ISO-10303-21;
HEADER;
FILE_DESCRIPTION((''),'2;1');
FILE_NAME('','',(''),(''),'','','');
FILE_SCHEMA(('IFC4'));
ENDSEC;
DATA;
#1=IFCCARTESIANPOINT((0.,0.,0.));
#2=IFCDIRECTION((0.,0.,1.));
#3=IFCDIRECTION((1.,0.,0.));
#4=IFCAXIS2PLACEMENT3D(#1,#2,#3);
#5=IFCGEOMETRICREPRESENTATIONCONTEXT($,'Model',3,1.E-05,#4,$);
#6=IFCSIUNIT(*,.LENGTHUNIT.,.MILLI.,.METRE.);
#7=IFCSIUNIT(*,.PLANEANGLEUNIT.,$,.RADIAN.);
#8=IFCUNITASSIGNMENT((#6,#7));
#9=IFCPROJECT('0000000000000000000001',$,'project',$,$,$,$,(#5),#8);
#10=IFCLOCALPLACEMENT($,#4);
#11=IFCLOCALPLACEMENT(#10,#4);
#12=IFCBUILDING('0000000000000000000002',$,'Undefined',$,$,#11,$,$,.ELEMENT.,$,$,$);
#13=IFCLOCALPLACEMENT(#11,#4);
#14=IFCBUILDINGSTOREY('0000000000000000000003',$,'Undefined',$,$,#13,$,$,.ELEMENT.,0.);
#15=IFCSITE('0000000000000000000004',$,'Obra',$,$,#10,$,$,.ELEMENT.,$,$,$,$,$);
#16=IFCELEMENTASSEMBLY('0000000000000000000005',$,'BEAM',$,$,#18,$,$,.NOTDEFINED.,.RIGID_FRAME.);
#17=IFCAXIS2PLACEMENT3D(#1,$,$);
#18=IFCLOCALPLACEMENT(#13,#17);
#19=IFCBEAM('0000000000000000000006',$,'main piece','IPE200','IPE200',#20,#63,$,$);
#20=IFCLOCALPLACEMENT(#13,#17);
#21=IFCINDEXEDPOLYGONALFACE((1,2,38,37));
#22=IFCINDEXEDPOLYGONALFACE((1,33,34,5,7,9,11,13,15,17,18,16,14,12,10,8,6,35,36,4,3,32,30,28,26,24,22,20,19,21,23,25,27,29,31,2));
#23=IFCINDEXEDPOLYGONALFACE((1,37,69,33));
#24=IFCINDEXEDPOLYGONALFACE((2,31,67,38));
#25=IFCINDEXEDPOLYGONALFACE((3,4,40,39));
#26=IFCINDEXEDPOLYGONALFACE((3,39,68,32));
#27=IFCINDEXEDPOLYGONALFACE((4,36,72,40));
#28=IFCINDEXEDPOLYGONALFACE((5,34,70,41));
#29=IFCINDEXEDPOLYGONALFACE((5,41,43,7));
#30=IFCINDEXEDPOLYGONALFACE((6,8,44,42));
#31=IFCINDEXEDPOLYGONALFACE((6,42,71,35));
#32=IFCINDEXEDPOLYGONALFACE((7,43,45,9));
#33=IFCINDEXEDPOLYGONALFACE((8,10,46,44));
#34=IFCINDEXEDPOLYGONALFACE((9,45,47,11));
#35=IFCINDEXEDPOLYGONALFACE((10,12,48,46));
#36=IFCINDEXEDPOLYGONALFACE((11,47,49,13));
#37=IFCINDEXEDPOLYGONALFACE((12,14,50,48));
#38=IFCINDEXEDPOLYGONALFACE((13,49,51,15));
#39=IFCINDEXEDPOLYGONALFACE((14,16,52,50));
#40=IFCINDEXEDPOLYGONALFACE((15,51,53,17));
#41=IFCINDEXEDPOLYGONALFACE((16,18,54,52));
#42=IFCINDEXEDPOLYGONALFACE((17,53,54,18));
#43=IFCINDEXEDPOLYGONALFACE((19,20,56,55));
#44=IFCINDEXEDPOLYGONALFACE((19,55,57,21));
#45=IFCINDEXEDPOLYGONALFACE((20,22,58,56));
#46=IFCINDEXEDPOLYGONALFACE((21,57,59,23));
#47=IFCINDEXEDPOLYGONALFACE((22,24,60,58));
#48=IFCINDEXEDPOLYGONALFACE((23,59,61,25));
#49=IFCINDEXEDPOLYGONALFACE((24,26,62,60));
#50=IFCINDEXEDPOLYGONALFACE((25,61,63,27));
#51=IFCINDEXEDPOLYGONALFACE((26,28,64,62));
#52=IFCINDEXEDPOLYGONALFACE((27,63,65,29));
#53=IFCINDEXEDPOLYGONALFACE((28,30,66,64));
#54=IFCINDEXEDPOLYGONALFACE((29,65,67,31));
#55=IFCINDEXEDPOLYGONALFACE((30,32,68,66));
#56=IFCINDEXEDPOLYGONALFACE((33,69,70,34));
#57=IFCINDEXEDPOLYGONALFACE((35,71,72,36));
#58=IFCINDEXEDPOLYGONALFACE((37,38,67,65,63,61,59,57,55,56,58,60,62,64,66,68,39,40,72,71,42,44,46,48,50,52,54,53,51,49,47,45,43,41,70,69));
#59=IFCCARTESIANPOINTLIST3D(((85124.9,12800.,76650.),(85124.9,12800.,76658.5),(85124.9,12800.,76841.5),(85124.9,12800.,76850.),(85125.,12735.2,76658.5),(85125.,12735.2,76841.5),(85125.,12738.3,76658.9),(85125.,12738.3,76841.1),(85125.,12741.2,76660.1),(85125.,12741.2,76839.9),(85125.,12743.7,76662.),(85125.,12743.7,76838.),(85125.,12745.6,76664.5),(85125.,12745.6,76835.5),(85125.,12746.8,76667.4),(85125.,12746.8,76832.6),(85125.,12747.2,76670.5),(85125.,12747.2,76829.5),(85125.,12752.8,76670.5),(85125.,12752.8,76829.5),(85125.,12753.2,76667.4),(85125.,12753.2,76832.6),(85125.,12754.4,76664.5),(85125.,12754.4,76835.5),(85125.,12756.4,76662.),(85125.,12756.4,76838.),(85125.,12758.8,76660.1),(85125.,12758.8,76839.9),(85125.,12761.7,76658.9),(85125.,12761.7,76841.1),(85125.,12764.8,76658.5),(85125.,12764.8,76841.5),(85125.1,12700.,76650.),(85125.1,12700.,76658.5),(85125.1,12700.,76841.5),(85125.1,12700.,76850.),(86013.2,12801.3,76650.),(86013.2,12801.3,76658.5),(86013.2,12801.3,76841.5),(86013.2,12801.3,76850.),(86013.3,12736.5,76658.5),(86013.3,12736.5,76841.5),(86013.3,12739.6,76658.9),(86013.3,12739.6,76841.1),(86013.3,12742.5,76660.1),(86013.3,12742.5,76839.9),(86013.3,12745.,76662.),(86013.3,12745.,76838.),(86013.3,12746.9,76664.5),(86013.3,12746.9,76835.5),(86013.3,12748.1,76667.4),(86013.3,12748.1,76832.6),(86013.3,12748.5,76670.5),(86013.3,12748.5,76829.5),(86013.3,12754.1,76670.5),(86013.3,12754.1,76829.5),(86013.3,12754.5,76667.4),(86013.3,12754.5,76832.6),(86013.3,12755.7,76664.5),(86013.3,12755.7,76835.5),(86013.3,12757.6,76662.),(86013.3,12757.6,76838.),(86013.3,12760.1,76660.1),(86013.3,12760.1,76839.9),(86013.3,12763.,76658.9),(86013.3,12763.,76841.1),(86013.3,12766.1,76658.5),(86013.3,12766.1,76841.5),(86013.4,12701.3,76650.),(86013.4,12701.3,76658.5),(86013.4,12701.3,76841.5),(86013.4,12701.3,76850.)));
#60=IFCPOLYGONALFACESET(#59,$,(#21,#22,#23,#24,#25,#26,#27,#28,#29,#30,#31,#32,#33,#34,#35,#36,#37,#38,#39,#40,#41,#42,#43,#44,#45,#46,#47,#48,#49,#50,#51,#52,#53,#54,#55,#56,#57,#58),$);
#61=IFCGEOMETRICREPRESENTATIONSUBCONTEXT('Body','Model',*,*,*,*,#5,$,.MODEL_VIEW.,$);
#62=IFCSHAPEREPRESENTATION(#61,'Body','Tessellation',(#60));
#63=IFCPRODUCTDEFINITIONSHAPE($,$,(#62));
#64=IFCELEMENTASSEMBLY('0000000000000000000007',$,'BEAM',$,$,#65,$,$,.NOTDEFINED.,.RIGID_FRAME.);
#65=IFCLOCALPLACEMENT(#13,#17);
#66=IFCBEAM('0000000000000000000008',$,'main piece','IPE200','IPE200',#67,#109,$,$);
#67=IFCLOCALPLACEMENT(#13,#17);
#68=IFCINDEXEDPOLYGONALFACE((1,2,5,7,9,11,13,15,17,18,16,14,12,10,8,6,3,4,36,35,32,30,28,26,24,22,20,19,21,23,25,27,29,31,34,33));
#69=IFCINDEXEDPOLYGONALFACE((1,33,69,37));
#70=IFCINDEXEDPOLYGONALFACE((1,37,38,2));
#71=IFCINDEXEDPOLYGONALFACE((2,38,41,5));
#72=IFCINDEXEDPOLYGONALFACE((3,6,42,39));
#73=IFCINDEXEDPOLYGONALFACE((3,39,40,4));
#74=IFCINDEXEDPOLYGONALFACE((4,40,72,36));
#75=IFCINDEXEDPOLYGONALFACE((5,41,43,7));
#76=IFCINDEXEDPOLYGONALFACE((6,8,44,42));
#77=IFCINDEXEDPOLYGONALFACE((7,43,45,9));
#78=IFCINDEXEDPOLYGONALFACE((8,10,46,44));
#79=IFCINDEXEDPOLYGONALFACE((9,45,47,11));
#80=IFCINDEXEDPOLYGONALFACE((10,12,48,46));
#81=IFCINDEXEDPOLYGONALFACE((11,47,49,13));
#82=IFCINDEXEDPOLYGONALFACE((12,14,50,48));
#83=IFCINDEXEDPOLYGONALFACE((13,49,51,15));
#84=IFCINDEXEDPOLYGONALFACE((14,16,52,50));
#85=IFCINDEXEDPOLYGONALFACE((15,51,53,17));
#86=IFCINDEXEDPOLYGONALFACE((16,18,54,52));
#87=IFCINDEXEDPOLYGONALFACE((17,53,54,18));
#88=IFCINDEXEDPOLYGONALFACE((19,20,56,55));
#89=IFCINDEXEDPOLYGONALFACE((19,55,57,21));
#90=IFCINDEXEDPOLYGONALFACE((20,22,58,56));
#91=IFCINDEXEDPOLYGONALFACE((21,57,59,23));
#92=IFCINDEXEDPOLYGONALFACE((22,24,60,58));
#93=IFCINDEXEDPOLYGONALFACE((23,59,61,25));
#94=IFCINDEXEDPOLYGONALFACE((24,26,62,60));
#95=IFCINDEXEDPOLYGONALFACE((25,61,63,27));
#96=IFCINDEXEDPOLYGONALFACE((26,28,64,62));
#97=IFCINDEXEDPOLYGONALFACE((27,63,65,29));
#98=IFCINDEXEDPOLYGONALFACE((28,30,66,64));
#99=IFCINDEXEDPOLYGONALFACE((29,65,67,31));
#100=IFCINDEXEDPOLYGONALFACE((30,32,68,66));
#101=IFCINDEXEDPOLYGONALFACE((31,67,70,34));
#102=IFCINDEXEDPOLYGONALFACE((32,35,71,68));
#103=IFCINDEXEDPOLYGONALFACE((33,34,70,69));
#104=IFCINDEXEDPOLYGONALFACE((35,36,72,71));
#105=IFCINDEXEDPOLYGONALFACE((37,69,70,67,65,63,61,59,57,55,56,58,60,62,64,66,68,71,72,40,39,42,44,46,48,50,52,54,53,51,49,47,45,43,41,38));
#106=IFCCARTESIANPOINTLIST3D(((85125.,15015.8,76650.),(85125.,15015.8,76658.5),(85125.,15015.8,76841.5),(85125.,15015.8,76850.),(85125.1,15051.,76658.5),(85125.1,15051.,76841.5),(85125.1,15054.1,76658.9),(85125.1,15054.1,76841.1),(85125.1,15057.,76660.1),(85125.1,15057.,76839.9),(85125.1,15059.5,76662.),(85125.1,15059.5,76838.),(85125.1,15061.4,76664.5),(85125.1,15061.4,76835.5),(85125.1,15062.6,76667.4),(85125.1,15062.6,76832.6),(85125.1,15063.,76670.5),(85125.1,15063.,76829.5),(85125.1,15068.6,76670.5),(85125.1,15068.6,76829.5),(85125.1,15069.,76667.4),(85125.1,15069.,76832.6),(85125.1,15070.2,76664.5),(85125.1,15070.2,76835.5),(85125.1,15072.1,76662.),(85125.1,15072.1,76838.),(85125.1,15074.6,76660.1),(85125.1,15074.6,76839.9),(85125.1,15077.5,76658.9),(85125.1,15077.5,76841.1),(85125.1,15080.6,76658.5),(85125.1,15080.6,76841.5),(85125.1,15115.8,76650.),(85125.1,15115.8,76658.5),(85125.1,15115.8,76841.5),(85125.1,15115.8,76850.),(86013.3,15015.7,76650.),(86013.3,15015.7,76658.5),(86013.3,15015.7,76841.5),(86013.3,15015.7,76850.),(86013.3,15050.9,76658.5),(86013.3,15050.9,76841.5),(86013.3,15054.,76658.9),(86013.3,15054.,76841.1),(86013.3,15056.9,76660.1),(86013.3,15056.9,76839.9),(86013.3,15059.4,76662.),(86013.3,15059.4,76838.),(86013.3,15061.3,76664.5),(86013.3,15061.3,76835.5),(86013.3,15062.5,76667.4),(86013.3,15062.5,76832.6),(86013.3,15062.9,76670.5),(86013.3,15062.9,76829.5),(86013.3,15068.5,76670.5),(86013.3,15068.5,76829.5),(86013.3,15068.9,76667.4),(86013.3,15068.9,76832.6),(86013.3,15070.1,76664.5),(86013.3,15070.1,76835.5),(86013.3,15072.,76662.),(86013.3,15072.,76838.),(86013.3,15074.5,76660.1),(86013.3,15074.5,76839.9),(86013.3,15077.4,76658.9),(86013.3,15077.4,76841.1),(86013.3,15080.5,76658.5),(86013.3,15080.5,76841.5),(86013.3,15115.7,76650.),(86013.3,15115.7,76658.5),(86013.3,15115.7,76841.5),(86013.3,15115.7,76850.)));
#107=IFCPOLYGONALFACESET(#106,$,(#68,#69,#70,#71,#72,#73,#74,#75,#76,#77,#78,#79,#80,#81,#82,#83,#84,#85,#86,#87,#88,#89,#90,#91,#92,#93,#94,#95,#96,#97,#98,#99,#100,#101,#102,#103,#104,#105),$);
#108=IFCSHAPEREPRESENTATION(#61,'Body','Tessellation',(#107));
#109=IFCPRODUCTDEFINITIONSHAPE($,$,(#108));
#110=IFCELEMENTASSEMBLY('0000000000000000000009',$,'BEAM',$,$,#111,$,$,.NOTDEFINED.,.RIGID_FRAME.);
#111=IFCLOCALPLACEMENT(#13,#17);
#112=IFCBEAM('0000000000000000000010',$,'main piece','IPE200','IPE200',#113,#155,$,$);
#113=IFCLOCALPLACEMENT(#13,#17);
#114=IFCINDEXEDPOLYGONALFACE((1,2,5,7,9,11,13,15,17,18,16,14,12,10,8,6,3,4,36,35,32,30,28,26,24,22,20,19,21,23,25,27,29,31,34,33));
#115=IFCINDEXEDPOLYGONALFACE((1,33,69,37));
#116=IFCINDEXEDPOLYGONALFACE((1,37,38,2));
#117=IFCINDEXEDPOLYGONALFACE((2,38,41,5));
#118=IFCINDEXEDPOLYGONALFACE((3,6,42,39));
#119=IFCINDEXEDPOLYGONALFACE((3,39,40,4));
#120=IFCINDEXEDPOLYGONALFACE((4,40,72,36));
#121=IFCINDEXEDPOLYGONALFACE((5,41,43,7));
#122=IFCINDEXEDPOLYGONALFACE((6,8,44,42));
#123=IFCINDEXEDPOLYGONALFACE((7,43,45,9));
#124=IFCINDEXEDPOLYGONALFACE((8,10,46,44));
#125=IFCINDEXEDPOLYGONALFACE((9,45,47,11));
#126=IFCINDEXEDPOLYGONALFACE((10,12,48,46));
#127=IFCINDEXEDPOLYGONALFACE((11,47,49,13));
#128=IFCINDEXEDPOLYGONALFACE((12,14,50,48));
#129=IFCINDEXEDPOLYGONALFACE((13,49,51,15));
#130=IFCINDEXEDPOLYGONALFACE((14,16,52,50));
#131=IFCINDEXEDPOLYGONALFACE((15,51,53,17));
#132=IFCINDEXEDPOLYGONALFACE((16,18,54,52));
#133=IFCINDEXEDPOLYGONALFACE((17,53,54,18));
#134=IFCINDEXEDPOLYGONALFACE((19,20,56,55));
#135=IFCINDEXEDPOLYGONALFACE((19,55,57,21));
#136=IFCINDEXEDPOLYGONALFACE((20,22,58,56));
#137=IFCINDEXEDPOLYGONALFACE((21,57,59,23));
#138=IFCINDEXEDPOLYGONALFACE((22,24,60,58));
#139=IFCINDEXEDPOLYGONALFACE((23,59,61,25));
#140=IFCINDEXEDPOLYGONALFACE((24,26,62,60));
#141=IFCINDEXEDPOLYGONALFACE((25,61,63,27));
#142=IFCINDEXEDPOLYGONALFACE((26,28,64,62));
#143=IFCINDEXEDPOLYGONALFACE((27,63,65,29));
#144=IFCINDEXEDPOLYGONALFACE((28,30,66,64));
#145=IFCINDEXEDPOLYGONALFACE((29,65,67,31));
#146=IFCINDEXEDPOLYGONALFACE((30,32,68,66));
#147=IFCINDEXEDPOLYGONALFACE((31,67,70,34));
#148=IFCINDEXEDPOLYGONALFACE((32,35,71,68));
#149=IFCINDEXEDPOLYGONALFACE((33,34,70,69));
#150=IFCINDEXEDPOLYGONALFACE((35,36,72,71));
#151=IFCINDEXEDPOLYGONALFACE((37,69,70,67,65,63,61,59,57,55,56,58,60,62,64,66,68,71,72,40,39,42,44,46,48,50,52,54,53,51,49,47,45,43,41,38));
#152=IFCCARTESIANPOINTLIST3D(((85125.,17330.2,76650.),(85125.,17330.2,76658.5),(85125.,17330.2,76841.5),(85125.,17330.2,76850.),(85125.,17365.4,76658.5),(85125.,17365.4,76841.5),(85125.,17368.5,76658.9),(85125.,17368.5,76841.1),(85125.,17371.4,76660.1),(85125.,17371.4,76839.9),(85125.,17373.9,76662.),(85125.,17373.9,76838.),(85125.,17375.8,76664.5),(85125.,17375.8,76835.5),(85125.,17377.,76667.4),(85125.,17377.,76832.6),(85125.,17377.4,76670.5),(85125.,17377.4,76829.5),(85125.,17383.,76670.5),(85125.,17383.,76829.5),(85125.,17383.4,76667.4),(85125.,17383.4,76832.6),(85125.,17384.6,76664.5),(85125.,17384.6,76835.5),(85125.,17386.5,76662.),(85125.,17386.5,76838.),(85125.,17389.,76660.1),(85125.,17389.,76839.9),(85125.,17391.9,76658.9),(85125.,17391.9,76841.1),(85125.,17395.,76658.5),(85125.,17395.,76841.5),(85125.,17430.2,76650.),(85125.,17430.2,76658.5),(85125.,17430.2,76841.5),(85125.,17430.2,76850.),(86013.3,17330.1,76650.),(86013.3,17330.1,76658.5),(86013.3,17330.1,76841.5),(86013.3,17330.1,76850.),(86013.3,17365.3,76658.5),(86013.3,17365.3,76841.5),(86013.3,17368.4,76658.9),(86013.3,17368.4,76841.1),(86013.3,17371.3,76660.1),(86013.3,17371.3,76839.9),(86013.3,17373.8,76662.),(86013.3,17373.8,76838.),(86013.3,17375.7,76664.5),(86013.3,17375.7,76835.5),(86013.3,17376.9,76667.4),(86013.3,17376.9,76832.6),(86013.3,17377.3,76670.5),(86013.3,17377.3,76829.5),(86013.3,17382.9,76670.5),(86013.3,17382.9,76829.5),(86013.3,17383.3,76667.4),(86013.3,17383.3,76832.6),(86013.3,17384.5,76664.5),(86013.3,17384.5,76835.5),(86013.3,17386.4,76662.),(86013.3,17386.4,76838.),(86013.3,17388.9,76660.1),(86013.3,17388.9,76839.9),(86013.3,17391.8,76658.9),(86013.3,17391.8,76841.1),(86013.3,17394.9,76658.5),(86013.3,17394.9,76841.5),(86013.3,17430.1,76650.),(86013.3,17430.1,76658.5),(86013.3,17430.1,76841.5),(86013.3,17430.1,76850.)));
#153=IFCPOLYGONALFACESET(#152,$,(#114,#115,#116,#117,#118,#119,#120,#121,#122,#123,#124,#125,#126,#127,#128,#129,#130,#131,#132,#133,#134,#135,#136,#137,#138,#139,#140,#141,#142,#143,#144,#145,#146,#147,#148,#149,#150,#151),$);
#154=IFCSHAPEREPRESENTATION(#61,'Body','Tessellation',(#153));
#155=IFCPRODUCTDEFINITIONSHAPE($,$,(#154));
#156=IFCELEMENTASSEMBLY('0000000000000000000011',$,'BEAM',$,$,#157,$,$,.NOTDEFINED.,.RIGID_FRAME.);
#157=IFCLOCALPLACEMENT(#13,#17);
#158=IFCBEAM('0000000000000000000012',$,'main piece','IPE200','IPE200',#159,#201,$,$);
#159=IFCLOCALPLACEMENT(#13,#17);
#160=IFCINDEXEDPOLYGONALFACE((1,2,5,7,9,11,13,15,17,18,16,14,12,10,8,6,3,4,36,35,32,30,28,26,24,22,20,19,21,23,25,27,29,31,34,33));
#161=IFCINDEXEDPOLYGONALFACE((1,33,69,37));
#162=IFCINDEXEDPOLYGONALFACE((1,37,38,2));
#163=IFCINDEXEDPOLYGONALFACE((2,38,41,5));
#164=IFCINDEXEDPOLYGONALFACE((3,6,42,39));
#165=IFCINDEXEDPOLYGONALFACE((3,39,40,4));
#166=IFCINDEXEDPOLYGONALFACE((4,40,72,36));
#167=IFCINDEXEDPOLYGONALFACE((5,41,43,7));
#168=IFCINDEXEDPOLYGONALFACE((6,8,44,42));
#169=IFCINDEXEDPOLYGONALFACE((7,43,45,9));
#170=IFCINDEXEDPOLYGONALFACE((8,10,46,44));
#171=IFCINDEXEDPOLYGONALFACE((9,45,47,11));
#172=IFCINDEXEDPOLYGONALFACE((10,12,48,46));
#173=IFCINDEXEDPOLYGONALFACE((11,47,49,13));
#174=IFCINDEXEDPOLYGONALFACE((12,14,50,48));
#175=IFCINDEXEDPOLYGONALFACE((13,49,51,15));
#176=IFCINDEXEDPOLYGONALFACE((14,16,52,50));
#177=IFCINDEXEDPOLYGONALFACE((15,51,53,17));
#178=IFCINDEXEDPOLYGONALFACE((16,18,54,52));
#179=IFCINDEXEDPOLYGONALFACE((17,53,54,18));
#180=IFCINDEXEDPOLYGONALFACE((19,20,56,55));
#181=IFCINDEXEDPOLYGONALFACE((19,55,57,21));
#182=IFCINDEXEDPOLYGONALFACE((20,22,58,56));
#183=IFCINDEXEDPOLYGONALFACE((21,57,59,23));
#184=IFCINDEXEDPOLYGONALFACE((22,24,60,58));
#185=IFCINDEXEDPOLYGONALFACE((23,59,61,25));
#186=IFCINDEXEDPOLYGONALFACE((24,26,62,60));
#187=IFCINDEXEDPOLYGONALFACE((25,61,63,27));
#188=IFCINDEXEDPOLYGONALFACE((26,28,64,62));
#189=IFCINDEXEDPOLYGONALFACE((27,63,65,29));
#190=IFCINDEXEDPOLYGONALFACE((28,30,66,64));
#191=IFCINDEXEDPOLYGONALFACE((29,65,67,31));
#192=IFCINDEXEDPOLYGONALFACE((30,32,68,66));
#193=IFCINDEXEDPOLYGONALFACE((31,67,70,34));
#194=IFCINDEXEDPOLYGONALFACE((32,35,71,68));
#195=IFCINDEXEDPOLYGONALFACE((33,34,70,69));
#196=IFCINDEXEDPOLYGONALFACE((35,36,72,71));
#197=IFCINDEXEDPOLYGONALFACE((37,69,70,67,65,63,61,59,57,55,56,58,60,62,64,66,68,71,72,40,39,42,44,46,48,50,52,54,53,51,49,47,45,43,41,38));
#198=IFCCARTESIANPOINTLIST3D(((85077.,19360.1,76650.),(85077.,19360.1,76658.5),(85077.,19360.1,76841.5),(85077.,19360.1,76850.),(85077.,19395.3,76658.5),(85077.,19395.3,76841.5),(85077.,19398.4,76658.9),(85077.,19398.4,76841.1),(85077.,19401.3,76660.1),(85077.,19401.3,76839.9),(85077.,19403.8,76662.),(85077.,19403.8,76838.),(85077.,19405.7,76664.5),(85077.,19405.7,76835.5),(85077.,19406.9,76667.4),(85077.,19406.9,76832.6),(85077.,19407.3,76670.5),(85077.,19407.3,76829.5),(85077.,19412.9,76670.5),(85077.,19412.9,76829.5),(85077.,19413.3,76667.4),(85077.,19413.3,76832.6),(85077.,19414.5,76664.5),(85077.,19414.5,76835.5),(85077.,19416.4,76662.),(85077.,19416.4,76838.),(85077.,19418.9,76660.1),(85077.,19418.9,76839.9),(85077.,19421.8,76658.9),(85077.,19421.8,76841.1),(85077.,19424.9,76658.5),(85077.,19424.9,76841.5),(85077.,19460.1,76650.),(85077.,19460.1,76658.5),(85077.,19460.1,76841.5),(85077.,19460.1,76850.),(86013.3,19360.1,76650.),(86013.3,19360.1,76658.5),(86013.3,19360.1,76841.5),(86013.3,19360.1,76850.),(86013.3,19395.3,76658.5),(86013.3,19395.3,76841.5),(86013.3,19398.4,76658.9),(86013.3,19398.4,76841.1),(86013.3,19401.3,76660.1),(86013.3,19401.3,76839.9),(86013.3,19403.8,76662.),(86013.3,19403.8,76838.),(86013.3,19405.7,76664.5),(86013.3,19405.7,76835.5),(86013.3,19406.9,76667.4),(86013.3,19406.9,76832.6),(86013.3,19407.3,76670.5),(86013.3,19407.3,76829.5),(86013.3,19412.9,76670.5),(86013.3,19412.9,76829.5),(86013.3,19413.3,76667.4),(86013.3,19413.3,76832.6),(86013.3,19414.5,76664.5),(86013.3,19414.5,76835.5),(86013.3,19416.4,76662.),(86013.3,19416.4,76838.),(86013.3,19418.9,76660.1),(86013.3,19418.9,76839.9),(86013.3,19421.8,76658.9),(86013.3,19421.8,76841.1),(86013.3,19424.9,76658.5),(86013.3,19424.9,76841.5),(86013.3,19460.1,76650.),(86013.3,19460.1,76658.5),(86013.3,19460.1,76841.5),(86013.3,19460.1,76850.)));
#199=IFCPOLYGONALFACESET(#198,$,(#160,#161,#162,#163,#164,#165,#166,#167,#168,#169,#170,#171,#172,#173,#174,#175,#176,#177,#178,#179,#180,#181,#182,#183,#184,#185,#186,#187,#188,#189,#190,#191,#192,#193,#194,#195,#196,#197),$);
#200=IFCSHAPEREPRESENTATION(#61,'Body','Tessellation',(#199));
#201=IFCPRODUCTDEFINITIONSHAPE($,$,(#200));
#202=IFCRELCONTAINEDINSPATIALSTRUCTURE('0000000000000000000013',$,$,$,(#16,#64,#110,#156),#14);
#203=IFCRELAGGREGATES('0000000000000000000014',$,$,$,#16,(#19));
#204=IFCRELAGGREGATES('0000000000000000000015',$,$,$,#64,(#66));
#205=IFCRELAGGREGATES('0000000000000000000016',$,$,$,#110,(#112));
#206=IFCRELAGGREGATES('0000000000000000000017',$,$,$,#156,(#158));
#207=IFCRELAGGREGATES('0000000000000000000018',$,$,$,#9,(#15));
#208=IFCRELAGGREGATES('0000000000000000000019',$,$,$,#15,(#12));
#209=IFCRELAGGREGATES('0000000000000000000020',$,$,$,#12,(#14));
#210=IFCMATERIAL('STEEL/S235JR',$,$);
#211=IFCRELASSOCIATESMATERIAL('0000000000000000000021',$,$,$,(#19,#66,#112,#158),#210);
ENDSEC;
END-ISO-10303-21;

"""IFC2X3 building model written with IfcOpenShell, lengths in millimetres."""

from ifc_helpers import new_model, si_unit, frame, origin_with_axes, origin_2d_with_axis, place, context, subcontext, project, spatial, i_section, extrude, material, element, aggregate, save


model = new_model("IFC2X3")

# Units and contexts
model_context = context("Model", 3, precision=1e-05, world=origin_with_axes())
body_context = subcontext(model_context, "Body", "Model", "MODEL_VIEW")
ifc_project = project(units=[si_unit("LENGTHUNIT", "METRE", prefix="MILLI"), si_unit("PLANEANGLEUNIT", "RADIAN")], contexts=[model_context])

# Site, building, storey
site_placement = place(None, origin_with_axes())
site = spatial("IfcSite", under=ifc_project, at=site_placement, Name="Obra", CompositionType="ELEMENT")
building_placement = place(site_placement, origin_with_axes())
building = spatial("IfcBuilding", under=site, at=building_placement, Name="Undefined", CompositionType="ELEMENT")
storey_placement = place(building_placement, origin_with_axes())
storey = spatial("IfcBuildingStorey", under=building, at=storey_placement, Name="Undefined", CompositionType="ELEMENT", Elevation=0.0)

# Element assemblies, beams
assembly_1_placement = place(storey_placement, origin_with_axes())
assembly_1 = element("IfcElementAssembly", 1, at=assembly_1_placement, inside=storey, Name="BEAM", AssemblyPlace="NOTDEFINED", PredefinedType="RIGID_FRAME")
ifc_material = material(Name="STEEL/S235JR")
beam_1_placement = place(assembly_1_placement, frame((85125.0, 12750.0, 76750.0), z_axis=(0.0, 0.0, 1.0), x_axis=(0.999999, 0.001449, 0.0)))
beam_1 = element("IfcBeam", 2, at=beam_1_placement, material=ifc_material, Name="main piece", Description="IPE200", ObjectType="IPE200", context=body_context, shape_type="SweptSolid", body=[
    extrude(i_section(OverallWidth=100.0, OverallDepth=200.0, WebThickness=5.6, FlangeThickness=8.5, FilletRadius=12.0, at=origin_2d_with_axis()), frame((888.3, 0.0, 0.0), z_axis=(-1.0, 0.0, 0.0), x_axis=(0.0, -1.0, 0.0)), (0.0, 0.0, 1.0), 888.3),
])
aggregate(assembly_1, [beam_1])
assembly_2_placement = place(storey_placement, origin_with_axes())
assembly_2 = element("IfcElementAssembly", 3, at=assembly_2_placement, inside=storey, Name="BEAM", AssemblyPlace="NOTDEFINED", PredefinedType="RIGID_FRAME")
beam_2_placement = place(assembly_2_placement, frame((85125.0, 15065.8, 76750.0), z_axis=(0.0, 0.0, 1.0), x_axis=(1.0, -0.000043, 0.0)))
beam_2 = element("IfcBeam", 4, at=beam_2_placement, material=ifc_material, Name="main piece", Description="IPE200", ObjectType="IPE200", context=body_context, shape_type="SweptSolid", body=[
    extrude(i_section(OverallWidth=100.0, OverallDepth=200.0, WebThickness=5.6, FlangeThickness=8.5, FilletRadius=12.0, at=origin_2d_with_axis()), frame((888.3, 0.0, 0.0), z_axis=(-1.0, 0.0, 0.0), x_axis=(0.0, -1.0, 0.0)), (0.0, 0.0, 1.0), 888.2),
])
aggregate(assembly_2, [beam_2])
assembly_3_placement = place(storey_placement, origin_with_axes())
assembly_3 = element("IfcElementAssembly", 5, at=assembly_3_placement, inside=storey, Name="BEAM", AssemblyPlace="NOTDEFINED", PredefinedType="RIGID_FRAME")
beam_3_placement = place(assembly_3_placement, frame((85125.0, 17380.2, 76750.0), z_axis=(0.0, 0.0, 1.0), x_axis=(1.0, -0.000084, 0.0)))
beam_3 = element("IfcBeam", 6, at=beam_3_placement, material=ifc_material, Name="main piece", Description="IPE200", ObjectType="IPE200", context=body_context, shape_type="SweptSolid", body=[
    extrude(i_section(OverallWidth=100.0, OverallDepth=200.0, WebThickness=5.6, FlangeThickness=8.5, FilletRadius=12.0, at=origin_2d_with_axis()), frame((888.3, 0.0, 0.0), z_axis=(-1.0, 0.0, 0.0), x_axis=(0.0, -1.0, 0.0)), (0.0, 0.0, 1.0), 888.3),
])
aggregate(assembly_3, [beam_3])
assembly_4_placement = place(storey_placement, origin_with_axes())
assembly_4 = element("IfcElementAssembly", 7, at=assembly_4_placement, inside=storey, Name="BEAM", AssemblyPlace="NOTDEFINED", PredefinedType="RIGID_FRAME")
beam_4_placement = place(assembly_4_placement, frame((85077.0, 19410.1, 76750.0), z_axis=(0.0, 0.0, 1.0), x_axis=(1.0, 0.0, 0.0)))
beam_4 = element("IfcBeam", 8, at=beam_4_placement, material=ifc_material, Name="main piece", Description="IPE200", ObjectType="IPE200", context=body_context, shape_type="SweptSolid", body=[
    extrude(i_section(OverallWidth=100.0, OverallDepth=200.0, WebThickness=5.6, FlangeThickness=8.5, FilletRadius=12.0, at=origin_2d_with_axis()), frame((936.3, 0.0, 0.0), z_axis=(-1.0, 0.0, 0.0), x_axis=(0.0, -1.0, 0.0)), (0.0, 0.0, 1.0), 936.3),
])
aggregate(assembly_4, [beam_4])

save(model, "model.ifc")
